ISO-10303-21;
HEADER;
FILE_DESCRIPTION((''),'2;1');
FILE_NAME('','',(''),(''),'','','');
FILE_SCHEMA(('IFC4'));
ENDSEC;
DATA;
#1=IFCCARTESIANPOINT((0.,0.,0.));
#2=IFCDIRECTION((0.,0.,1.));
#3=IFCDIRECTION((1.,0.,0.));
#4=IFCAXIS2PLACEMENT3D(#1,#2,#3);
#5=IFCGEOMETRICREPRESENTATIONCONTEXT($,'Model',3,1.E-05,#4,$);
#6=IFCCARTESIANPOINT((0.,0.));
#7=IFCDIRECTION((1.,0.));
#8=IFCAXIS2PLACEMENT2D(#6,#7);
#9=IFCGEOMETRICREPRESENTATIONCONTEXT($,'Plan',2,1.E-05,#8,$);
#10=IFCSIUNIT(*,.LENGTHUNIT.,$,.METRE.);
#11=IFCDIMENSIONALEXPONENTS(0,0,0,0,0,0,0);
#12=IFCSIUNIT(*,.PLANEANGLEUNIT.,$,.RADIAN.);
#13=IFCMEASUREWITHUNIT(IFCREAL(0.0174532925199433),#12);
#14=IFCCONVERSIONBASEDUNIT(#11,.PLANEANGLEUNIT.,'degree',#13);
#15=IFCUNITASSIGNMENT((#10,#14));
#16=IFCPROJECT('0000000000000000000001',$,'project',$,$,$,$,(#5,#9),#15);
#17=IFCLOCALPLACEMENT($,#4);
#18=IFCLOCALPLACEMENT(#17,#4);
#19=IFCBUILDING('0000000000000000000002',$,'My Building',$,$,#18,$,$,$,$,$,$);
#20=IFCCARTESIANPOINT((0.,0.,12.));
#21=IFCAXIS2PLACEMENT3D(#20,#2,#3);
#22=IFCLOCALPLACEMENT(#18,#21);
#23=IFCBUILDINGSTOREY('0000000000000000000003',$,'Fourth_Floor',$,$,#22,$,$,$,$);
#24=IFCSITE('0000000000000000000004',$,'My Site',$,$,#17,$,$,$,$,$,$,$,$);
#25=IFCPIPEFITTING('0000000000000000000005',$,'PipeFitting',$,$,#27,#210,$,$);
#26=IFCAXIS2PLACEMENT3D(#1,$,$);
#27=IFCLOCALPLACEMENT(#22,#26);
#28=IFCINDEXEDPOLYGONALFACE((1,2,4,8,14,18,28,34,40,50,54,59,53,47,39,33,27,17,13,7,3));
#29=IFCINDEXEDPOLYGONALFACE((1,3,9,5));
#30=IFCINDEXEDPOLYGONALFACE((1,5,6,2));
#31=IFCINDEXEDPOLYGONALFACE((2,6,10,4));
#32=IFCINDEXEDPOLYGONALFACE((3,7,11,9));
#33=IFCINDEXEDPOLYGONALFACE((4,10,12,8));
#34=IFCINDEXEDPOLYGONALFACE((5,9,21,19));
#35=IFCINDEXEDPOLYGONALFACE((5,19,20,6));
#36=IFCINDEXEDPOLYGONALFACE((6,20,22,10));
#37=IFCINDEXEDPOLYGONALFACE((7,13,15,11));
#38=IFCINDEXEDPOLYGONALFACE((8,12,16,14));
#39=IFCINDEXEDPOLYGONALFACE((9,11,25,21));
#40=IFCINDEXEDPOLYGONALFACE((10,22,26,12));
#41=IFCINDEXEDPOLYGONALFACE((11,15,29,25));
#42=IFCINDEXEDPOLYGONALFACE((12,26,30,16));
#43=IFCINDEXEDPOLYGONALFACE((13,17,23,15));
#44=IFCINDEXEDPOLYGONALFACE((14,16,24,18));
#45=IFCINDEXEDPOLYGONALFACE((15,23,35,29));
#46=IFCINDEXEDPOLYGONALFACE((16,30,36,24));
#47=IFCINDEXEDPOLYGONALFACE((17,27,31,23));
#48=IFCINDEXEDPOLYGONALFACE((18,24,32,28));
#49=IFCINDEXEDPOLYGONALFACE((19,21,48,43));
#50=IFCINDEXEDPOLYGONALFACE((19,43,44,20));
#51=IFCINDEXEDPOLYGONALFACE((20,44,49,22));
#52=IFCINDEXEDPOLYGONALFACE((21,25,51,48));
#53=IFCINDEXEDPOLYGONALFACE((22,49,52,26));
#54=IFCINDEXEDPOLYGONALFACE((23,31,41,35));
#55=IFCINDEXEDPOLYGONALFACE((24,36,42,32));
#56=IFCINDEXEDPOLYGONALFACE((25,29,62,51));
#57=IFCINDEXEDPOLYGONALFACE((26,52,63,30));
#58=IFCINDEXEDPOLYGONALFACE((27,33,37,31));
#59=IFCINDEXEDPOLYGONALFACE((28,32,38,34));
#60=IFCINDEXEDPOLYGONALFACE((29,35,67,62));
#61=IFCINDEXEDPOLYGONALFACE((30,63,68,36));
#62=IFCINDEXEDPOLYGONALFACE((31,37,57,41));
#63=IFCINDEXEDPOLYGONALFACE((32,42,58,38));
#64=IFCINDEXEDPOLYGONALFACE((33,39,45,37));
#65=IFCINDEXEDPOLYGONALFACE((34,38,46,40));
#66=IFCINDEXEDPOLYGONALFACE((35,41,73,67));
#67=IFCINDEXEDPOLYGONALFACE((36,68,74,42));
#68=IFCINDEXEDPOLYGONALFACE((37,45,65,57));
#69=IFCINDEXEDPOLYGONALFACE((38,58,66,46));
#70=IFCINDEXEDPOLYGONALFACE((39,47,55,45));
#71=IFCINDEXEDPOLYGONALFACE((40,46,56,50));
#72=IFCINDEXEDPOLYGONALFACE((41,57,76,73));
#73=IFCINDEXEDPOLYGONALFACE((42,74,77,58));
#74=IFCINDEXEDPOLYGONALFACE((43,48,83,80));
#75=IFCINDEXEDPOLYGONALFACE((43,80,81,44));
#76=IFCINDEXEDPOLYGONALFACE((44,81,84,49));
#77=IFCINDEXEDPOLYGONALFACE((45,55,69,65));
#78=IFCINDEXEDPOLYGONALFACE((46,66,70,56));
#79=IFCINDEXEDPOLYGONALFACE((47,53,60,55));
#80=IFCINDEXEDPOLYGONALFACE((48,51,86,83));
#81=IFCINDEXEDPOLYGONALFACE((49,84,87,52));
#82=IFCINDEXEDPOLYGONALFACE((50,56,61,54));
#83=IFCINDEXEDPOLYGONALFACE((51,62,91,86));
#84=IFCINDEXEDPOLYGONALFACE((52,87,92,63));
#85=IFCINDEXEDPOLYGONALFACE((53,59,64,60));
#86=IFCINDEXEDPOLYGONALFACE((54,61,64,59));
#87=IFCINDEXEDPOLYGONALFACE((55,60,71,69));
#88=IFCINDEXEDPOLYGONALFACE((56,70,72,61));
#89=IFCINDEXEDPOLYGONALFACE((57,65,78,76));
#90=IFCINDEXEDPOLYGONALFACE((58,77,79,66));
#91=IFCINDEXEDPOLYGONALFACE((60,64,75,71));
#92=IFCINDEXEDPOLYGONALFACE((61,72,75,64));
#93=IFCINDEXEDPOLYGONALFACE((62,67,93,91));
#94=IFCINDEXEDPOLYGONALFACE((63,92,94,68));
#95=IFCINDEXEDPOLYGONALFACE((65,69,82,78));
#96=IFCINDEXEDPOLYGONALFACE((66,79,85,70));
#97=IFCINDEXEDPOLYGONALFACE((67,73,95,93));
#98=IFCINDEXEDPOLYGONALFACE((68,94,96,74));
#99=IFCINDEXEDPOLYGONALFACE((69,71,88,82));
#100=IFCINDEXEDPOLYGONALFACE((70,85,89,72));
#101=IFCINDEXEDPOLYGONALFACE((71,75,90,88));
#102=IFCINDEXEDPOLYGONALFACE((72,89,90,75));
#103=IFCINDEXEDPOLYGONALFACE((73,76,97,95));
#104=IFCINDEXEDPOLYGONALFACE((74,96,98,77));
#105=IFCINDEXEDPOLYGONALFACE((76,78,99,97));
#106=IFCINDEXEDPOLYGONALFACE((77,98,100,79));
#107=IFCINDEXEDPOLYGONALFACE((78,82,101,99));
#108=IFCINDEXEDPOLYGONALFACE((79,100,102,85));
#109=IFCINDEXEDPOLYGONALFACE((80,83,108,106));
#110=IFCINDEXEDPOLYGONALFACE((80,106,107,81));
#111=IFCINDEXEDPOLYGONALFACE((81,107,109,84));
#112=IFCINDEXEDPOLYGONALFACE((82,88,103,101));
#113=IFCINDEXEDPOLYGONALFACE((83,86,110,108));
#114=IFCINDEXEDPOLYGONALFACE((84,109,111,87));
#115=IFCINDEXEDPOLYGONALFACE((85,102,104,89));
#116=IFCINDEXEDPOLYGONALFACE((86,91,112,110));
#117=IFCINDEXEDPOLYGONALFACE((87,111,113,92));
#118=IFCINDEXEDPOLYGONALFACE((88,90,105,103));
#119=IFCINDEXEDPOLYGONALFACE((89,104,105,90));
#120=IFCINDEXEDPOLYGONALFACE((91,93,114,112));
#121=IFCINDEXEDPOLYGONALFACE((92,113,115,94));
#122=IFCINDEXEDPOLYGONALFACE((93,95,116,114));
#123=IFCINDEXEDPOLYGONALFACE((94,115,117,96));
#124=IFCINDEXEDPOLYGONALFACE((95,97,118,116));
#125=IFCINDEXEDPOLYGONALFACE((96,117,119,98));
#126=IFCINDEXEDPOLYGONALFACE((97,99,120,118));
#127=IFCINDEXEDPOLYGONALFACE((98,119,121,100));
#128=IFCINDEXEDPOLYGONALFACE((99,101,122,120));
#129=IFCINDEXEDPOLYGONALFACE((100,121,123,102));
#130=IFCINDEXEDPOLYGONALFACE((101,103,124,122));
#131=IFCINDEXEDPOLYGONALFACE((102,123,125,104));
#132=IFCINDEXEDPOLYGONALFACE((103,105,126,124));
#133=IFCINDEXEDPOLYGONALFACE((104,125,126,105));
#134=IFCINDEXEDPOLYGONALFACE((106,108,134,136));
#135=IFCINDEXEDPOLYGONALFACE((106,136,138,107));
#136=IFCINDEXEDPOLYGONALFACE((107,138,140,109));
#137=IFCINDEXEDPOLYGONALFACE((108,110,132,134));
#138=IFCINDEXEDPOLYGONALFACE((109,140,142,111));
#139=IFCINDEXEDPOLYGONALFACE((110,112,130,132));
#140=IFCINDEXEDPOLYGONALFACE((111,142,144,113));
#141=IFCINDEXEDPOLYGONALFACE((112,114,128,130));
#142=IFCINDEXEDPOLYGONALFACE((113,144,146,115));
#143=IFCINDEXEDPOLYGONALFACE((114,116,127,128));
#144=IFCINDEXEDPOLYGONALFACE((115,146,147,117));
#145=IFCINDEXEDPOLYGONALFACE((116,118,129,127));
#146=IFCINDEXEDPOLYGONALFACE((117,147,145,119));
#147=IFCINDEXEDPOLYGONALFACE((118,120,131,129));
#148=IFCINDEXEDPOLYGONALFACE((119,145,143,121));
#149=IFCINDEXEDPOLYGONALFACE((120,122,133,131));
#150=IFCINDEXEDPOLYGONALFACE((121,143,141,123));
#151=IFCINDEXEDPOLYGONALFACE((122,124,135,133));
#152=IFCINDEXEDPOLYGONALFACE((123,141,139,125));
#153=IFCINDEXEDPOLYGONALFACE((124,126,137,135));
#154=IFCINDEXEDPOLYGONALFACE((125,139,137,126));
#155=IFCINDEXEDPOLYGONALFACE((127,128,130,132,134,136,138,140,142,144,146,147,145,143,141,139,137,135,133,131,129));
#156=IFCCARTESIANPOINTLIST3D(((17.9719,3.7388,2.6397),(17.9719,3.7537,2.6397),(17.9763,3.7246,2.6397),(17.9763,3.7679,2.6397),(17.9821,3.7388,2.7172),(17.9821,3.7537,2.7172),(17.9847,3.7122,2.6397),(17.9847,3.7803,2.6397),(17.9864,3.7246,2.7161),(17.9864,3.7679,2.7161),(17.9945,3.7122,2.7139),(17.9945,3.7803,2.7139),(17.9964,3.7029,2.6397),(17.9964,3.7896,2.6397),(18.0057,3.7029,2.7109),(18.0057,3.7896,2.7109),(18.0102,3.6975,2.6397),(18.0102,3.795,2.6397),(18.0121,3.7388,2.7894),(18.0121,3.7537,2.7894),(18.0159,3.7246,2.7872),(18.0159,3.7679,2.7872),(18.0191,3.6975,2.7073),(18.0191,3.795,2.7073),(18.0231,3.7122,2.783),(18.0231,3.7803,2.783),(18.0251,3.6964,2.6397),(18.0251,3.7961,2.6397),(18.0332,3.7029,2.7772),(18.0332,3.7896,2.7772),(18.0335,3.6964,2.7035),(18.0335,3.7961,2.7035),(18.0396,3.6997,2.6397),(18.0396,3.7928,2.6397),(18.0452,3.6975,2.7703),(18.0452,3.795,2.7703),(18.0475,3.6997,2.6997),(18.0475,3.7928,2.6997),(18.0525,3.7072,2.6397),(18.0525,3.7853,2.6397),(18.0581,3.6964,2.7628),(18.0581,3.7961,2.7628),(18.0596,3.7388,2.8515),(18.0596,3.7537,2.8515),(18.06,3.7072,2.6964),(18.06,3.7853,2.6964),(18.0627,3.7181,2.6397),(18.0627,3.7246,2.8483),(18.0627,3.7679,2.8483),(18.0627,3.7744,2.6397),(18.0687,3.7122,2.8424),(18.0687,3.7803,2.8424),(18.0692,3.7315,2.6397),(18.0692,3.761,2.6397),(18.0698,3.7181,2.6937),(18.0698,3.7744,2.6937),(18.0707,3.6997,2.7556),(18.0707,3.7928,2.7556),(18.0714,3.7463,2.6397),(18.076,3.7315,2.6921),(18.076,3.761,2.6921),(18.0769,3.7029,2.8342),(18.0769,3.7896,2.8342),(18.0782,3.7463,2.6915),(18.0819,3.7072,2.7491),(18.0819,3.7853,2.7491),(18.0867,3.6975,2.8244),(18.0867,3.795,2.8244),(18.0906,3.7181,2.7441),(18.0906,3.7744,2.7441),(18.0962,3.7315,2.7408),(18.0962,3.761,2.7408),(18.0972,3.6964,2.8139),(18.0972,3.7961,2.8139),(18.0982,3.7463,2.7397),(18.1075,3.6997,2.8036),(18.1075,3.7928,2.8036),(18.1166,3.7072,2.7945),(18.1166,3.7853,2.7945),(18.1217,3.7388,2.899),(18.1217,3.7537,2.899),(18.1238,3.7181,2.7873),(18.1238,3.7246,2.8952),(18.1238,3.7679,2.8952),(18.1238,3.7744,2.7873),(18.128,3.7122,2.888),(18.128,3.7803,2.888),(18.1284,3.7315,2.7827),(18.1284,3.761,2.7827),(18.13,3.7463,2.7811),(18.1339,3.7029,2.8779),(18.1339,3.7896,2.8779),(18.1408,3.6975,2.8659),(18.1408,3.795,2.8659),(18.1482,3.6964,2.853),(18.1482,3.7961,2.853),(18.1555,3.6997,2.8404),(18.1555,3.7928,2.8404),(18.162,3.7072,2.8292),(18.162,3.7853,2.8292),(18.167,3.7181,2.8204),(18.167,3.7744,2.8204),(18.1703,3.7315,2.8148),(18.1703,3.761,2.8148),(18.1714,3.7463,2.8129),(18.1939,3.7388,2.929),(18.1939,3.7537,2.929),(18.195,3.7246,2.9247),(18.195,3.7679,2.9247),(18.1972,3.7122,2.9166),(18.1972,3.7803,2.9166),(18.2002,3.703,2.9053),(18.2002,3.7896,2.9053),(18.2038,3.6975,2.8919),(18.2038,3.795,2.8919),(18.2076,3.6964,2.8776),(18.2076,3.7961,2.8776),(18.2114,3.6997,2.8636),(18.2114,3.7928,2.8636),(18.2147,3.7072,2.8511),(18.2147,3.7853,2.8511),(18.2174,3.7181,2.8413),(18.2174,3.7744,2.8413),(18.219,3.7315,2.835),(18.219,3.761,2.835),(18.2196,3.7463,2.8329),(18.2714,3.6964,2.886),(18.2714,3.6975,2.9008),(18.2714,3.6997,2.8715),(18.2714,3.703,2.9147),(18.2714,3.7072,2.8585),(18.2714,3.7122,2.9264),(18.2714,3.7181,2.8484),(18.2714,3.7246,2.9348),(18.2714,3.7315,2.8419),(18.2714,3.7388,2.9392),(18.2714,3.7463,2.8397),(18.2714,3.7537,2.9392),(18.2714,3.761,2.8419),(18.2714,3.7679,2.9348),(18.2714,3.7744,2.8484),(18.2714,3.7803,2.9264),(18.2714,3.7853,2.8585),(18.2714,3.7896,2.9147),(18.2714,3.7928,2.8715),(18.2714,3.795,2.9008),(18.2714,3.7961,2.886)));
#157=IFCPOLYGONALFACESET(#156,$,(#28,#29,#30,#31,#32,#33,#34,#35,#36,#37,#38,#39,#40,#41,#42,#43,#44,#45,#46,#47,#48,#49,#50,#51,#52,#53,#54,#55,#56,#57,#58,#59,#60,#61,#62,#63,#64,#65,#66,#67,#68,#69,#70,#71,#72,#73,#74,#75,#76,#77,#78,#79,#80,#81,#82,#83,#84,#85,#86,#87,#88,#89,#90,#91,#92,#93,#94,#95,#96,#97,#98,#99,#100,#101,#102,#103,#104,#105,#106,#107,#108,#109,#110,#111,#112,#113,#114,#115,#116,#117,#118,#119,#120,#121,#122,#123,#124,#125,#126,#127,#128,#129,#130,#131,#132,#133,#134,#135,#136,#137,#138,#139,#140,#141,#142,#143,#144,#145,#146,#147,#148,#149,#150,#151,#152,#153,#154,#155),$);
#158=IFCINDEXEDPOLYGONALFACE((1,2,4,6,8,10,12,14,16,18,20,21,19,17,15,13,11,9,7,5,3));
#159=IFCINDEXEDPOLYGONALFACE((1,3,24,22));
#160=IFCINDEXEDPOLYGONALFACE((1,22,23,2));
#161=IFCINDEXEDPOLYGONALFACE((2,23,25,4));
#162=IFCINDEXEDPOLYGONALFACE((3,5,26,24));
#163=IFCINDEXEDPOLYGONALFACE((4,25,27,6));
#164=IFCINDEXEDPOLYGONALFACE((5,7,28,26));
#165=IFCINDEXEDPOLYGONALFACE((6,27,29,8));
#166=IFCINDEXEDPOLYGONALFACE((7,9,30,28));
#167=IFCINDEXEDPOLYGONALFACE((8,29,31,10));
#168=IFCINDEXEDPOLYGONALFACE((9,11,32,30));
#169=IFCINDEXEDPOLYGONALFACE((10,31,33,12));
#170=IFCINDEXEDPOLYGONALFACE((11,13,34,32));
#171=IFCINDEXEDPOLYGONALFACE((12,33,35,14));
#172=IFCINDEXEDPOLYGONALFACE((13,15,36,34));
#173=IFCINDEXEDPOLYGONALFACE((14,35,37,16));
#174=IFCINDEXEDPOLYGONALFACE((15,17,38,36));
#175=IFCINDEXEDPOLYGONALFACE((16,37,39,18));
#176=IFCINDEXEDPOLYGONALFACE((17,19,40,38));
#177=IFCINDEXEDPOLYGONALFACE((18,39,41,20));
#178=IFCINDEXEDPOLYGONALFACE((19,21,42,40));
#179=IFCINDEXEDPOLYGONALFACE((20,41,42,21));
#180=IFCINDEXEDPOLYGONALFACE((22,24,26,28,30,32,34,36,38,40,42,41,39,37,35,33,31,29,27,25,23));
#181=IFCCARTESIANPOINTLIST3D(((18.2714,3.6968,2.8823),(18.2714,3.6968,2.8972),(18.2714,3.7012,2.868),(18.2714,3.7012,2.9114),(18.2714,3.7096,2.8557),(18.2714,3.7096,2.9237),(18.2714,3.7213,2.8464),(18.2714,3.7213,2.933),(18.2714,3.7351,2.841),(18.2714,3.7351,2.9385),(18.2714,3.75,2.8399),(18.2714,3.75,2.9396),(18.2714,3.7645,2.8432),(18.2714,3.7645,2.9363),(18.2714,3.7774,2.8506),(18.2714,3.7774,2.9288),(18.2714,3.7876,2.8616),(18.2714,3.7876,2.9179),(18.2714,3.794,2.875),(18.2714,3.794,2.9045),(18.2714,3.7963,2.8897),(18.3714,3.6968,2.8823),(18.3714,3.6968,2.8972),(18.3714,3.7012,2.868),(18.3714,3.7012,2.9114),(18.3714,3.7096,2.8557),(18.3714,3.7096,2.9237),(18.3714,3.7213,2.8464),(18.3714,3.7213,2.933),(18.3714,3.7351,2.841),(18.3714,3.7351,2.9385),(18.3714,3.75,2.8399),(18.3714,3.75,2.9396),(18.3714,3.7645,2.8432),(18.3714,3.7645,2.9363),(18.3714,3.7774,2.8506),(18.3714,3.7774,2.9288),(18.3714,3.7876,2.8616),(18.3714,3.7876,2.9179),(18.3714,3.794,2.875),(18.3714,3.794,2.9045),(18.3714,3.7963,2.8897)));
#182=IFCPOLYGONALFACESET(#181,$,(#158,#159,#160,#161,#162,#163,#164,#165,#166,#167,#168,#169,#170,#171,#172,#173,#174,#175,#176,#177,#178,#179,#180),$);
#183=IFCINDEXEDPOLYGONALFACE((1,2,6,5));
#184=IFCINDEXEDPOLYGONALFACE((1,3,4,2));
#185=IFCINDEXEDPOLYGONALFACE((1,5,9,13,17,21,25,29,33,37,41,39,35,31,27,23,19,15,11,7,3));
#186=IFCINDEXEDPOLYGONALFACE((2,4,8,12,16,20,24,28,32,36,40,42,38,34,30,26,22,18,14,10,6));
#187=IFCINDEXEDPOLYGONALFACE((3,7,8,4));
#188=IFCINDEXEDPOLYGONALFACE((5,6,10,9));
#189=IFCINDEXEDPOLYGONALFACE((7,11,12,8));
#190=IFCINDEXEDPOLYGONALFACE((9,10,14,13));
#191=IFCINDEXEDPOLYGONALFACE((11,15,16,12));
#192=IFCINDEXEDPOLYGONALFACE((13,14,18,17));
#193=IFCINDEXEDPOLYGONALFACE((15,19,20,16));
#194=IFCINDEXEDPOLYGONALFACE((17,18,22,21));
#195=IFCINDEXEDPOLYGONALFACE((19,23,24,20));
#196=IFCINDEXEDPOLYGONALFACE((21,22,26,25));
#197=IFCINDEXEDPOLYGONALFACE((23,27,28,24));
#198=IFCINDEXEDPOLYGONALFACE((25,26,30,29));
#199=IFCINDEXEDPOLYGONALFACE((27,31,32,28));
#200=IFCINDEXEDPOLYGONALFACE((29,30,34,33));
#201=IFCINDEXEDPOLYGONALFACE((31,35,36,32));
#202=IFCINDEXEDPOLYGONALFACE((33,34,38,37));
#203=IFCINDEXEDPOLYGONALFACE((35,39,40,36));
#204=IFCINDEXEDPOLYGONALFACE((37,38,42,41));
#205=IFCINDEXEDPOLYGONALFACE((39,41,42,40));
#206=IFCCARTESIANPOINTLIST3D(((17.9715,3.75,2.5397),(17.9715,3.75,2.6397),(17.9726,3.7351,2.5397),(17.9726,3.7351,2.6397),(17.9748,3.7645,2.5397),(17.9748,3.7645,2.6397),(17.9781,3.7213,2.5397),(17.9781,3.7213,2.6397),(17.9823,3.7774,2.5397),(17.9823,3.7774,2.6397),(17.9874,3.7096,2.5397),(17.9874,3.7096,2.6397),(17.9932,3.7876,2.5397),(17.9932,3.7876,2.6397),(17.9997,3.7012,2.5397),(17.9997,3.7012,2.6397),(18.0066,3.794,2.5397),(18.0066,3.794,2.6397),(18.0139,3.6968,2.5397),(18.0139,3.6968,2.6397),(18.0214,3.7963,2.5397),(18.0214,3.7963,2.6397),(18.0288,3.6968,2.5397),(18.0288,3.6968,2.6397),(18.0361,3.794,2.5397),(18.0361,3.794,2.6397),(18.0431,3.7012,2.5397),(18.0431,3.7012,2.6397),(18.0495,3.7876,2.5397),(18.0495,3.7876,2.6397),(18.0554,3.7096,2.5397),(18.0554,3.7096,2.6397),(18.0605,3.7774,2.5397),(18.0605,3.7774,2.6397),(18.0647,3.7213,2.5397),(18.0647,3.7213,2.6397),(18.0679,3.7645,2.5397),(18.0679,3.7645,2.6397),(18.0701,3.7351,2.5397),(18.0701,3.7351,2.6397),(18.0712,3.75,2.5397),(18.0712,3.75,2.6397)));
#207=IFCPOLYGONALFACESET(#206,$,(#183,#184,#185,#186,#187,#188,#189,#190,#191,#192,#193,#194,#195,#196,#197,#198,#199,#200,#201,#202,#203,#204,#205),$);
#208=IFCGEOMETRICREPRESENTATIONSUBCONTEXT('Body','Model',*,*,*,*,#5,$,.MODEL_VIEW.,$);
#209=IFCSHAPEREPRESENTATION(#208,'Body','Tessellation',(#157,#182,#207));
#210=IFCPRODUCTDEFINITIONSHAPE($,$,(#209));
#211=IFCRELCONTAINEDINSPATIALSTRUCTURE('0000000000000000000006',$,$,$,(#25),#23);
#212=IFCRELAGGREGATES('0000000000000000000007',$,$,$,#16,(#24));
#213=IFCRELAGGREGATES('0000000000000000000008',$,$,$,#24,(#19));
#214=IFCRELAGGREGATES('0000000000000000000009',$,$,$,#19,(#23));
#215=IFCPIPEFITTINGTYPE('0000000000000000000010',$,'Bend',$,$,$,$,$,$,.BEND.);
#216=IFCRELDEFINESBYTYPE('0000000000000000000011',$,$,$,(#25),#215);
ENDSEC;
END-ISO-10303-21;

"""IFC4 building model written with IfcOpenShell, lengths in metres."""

from ifc_helpers import new_model, entity, si_unit, converted_unit, frame, origin_with_axes, origin_2d_with_axis, place, context, subcontext, project, spatial, circle, extrude, source, transform, mapped, type_object, type_shapes, element, save


model = new_model("IFC4")

# Units and contexts
model_context = context("Model", 3, precision=1e-05, world=origin_with_axes())
plan_context = context("Plan", 2, precision=1e-05, world=origin_2d_with_axis())
body_context_1 = subcontext(model_context, "Body", "Model", "MODEL_VIEW")
ifc_project = project(units=[si_unit("LENGTHUNIT", "METRE"), converted_unit("PLANEANGLEUNIT", "degree", entity("IfcReal", 0.0174532925199433), si_unit("PLANEANGLEUNIT", "RADIAN"), dimensions=[0, 0, 0, 0, 0, 0, 0])], contexts=[model_context, plan_context])

# Site, building, storey
site_placement = place(None, origin_with_axes())
site = spatial("IfcSite", under=ifc_project, at=site_placement, Name="My Site")
building_placement = place(site_placement, origin_with_axes())
building = spatial("IfcBuilding", under=site, at=building_placement, Name="My Building")
storey_placement = place(building_placement, frame((0.0, 0.0, 12.0), z_axis=(0.0, 0.0, 1.0), x_axis=(1.0, 0.0, 0.0)))
storey = spatial("IfcBuildingStorey", under=building, at=storey_placement, Name="Fourth_Floor")

# Pipe fitting
pipe_fitting_type = type_object("IfcPipeFittingType", Name="Bend", PredefinedType="BEND")
shared_shape_1 = source(origin_with_axes(), body_context_1, "Body", "SolidModel", [
    entity("IfcSweptDiskSolid", entity("IfcIndexedPolyCurve", entity("IfcCartesianPointList3D", [[0.0, 0.0, -0.1], [0.0, -0.0732, -0.2768], [0.0, -0.25, -0.35]]), [entity("IfcArcIndex", [1, 2, 3])]), 0.05),
    extrude(circle(Radius=0.05), origin_with_axes(), (0.0, 0.0, -1.0), 0.1),
    extrude(circle(Radius=0.05), frame((0.0, -0.25, -0.35), z_axis=(0.0, -1.0, 0.0), x_axis=(1.0, 0.0, 0.0)), (0.0, 0.0, 1.0), 0.1),
])
type_shapes(pipe_fitting_type, [shared_shape_1])
for number, where, z_axis, x_axis, name in (
    (1, (18.3714, 3.7463, 2.8897), (1.0, 0.0, 0.0), (0.0, 1.0, 0.0), "PipeFitting"),
):
    element("IfcPipeFitting", number, at=place(storey_placement, frame(where, z_axis=z_axis, x_axis=x_axis)), inside=storey, type_object=pipe_fitting_type, Name=name, context=body_context_1, shape_type="MappedRepresentation", body=[
        mapped(shared_shape_1, transform((0.0, 0.0, 0.0), x_axis=(1.0, 0.0, 0.0), y_axis=(0.0, 1.0, 0.0), z_axis=(0.0, 0.0, 1.0), scale=1.0)),
    ])

save(model, "model.ifc")
